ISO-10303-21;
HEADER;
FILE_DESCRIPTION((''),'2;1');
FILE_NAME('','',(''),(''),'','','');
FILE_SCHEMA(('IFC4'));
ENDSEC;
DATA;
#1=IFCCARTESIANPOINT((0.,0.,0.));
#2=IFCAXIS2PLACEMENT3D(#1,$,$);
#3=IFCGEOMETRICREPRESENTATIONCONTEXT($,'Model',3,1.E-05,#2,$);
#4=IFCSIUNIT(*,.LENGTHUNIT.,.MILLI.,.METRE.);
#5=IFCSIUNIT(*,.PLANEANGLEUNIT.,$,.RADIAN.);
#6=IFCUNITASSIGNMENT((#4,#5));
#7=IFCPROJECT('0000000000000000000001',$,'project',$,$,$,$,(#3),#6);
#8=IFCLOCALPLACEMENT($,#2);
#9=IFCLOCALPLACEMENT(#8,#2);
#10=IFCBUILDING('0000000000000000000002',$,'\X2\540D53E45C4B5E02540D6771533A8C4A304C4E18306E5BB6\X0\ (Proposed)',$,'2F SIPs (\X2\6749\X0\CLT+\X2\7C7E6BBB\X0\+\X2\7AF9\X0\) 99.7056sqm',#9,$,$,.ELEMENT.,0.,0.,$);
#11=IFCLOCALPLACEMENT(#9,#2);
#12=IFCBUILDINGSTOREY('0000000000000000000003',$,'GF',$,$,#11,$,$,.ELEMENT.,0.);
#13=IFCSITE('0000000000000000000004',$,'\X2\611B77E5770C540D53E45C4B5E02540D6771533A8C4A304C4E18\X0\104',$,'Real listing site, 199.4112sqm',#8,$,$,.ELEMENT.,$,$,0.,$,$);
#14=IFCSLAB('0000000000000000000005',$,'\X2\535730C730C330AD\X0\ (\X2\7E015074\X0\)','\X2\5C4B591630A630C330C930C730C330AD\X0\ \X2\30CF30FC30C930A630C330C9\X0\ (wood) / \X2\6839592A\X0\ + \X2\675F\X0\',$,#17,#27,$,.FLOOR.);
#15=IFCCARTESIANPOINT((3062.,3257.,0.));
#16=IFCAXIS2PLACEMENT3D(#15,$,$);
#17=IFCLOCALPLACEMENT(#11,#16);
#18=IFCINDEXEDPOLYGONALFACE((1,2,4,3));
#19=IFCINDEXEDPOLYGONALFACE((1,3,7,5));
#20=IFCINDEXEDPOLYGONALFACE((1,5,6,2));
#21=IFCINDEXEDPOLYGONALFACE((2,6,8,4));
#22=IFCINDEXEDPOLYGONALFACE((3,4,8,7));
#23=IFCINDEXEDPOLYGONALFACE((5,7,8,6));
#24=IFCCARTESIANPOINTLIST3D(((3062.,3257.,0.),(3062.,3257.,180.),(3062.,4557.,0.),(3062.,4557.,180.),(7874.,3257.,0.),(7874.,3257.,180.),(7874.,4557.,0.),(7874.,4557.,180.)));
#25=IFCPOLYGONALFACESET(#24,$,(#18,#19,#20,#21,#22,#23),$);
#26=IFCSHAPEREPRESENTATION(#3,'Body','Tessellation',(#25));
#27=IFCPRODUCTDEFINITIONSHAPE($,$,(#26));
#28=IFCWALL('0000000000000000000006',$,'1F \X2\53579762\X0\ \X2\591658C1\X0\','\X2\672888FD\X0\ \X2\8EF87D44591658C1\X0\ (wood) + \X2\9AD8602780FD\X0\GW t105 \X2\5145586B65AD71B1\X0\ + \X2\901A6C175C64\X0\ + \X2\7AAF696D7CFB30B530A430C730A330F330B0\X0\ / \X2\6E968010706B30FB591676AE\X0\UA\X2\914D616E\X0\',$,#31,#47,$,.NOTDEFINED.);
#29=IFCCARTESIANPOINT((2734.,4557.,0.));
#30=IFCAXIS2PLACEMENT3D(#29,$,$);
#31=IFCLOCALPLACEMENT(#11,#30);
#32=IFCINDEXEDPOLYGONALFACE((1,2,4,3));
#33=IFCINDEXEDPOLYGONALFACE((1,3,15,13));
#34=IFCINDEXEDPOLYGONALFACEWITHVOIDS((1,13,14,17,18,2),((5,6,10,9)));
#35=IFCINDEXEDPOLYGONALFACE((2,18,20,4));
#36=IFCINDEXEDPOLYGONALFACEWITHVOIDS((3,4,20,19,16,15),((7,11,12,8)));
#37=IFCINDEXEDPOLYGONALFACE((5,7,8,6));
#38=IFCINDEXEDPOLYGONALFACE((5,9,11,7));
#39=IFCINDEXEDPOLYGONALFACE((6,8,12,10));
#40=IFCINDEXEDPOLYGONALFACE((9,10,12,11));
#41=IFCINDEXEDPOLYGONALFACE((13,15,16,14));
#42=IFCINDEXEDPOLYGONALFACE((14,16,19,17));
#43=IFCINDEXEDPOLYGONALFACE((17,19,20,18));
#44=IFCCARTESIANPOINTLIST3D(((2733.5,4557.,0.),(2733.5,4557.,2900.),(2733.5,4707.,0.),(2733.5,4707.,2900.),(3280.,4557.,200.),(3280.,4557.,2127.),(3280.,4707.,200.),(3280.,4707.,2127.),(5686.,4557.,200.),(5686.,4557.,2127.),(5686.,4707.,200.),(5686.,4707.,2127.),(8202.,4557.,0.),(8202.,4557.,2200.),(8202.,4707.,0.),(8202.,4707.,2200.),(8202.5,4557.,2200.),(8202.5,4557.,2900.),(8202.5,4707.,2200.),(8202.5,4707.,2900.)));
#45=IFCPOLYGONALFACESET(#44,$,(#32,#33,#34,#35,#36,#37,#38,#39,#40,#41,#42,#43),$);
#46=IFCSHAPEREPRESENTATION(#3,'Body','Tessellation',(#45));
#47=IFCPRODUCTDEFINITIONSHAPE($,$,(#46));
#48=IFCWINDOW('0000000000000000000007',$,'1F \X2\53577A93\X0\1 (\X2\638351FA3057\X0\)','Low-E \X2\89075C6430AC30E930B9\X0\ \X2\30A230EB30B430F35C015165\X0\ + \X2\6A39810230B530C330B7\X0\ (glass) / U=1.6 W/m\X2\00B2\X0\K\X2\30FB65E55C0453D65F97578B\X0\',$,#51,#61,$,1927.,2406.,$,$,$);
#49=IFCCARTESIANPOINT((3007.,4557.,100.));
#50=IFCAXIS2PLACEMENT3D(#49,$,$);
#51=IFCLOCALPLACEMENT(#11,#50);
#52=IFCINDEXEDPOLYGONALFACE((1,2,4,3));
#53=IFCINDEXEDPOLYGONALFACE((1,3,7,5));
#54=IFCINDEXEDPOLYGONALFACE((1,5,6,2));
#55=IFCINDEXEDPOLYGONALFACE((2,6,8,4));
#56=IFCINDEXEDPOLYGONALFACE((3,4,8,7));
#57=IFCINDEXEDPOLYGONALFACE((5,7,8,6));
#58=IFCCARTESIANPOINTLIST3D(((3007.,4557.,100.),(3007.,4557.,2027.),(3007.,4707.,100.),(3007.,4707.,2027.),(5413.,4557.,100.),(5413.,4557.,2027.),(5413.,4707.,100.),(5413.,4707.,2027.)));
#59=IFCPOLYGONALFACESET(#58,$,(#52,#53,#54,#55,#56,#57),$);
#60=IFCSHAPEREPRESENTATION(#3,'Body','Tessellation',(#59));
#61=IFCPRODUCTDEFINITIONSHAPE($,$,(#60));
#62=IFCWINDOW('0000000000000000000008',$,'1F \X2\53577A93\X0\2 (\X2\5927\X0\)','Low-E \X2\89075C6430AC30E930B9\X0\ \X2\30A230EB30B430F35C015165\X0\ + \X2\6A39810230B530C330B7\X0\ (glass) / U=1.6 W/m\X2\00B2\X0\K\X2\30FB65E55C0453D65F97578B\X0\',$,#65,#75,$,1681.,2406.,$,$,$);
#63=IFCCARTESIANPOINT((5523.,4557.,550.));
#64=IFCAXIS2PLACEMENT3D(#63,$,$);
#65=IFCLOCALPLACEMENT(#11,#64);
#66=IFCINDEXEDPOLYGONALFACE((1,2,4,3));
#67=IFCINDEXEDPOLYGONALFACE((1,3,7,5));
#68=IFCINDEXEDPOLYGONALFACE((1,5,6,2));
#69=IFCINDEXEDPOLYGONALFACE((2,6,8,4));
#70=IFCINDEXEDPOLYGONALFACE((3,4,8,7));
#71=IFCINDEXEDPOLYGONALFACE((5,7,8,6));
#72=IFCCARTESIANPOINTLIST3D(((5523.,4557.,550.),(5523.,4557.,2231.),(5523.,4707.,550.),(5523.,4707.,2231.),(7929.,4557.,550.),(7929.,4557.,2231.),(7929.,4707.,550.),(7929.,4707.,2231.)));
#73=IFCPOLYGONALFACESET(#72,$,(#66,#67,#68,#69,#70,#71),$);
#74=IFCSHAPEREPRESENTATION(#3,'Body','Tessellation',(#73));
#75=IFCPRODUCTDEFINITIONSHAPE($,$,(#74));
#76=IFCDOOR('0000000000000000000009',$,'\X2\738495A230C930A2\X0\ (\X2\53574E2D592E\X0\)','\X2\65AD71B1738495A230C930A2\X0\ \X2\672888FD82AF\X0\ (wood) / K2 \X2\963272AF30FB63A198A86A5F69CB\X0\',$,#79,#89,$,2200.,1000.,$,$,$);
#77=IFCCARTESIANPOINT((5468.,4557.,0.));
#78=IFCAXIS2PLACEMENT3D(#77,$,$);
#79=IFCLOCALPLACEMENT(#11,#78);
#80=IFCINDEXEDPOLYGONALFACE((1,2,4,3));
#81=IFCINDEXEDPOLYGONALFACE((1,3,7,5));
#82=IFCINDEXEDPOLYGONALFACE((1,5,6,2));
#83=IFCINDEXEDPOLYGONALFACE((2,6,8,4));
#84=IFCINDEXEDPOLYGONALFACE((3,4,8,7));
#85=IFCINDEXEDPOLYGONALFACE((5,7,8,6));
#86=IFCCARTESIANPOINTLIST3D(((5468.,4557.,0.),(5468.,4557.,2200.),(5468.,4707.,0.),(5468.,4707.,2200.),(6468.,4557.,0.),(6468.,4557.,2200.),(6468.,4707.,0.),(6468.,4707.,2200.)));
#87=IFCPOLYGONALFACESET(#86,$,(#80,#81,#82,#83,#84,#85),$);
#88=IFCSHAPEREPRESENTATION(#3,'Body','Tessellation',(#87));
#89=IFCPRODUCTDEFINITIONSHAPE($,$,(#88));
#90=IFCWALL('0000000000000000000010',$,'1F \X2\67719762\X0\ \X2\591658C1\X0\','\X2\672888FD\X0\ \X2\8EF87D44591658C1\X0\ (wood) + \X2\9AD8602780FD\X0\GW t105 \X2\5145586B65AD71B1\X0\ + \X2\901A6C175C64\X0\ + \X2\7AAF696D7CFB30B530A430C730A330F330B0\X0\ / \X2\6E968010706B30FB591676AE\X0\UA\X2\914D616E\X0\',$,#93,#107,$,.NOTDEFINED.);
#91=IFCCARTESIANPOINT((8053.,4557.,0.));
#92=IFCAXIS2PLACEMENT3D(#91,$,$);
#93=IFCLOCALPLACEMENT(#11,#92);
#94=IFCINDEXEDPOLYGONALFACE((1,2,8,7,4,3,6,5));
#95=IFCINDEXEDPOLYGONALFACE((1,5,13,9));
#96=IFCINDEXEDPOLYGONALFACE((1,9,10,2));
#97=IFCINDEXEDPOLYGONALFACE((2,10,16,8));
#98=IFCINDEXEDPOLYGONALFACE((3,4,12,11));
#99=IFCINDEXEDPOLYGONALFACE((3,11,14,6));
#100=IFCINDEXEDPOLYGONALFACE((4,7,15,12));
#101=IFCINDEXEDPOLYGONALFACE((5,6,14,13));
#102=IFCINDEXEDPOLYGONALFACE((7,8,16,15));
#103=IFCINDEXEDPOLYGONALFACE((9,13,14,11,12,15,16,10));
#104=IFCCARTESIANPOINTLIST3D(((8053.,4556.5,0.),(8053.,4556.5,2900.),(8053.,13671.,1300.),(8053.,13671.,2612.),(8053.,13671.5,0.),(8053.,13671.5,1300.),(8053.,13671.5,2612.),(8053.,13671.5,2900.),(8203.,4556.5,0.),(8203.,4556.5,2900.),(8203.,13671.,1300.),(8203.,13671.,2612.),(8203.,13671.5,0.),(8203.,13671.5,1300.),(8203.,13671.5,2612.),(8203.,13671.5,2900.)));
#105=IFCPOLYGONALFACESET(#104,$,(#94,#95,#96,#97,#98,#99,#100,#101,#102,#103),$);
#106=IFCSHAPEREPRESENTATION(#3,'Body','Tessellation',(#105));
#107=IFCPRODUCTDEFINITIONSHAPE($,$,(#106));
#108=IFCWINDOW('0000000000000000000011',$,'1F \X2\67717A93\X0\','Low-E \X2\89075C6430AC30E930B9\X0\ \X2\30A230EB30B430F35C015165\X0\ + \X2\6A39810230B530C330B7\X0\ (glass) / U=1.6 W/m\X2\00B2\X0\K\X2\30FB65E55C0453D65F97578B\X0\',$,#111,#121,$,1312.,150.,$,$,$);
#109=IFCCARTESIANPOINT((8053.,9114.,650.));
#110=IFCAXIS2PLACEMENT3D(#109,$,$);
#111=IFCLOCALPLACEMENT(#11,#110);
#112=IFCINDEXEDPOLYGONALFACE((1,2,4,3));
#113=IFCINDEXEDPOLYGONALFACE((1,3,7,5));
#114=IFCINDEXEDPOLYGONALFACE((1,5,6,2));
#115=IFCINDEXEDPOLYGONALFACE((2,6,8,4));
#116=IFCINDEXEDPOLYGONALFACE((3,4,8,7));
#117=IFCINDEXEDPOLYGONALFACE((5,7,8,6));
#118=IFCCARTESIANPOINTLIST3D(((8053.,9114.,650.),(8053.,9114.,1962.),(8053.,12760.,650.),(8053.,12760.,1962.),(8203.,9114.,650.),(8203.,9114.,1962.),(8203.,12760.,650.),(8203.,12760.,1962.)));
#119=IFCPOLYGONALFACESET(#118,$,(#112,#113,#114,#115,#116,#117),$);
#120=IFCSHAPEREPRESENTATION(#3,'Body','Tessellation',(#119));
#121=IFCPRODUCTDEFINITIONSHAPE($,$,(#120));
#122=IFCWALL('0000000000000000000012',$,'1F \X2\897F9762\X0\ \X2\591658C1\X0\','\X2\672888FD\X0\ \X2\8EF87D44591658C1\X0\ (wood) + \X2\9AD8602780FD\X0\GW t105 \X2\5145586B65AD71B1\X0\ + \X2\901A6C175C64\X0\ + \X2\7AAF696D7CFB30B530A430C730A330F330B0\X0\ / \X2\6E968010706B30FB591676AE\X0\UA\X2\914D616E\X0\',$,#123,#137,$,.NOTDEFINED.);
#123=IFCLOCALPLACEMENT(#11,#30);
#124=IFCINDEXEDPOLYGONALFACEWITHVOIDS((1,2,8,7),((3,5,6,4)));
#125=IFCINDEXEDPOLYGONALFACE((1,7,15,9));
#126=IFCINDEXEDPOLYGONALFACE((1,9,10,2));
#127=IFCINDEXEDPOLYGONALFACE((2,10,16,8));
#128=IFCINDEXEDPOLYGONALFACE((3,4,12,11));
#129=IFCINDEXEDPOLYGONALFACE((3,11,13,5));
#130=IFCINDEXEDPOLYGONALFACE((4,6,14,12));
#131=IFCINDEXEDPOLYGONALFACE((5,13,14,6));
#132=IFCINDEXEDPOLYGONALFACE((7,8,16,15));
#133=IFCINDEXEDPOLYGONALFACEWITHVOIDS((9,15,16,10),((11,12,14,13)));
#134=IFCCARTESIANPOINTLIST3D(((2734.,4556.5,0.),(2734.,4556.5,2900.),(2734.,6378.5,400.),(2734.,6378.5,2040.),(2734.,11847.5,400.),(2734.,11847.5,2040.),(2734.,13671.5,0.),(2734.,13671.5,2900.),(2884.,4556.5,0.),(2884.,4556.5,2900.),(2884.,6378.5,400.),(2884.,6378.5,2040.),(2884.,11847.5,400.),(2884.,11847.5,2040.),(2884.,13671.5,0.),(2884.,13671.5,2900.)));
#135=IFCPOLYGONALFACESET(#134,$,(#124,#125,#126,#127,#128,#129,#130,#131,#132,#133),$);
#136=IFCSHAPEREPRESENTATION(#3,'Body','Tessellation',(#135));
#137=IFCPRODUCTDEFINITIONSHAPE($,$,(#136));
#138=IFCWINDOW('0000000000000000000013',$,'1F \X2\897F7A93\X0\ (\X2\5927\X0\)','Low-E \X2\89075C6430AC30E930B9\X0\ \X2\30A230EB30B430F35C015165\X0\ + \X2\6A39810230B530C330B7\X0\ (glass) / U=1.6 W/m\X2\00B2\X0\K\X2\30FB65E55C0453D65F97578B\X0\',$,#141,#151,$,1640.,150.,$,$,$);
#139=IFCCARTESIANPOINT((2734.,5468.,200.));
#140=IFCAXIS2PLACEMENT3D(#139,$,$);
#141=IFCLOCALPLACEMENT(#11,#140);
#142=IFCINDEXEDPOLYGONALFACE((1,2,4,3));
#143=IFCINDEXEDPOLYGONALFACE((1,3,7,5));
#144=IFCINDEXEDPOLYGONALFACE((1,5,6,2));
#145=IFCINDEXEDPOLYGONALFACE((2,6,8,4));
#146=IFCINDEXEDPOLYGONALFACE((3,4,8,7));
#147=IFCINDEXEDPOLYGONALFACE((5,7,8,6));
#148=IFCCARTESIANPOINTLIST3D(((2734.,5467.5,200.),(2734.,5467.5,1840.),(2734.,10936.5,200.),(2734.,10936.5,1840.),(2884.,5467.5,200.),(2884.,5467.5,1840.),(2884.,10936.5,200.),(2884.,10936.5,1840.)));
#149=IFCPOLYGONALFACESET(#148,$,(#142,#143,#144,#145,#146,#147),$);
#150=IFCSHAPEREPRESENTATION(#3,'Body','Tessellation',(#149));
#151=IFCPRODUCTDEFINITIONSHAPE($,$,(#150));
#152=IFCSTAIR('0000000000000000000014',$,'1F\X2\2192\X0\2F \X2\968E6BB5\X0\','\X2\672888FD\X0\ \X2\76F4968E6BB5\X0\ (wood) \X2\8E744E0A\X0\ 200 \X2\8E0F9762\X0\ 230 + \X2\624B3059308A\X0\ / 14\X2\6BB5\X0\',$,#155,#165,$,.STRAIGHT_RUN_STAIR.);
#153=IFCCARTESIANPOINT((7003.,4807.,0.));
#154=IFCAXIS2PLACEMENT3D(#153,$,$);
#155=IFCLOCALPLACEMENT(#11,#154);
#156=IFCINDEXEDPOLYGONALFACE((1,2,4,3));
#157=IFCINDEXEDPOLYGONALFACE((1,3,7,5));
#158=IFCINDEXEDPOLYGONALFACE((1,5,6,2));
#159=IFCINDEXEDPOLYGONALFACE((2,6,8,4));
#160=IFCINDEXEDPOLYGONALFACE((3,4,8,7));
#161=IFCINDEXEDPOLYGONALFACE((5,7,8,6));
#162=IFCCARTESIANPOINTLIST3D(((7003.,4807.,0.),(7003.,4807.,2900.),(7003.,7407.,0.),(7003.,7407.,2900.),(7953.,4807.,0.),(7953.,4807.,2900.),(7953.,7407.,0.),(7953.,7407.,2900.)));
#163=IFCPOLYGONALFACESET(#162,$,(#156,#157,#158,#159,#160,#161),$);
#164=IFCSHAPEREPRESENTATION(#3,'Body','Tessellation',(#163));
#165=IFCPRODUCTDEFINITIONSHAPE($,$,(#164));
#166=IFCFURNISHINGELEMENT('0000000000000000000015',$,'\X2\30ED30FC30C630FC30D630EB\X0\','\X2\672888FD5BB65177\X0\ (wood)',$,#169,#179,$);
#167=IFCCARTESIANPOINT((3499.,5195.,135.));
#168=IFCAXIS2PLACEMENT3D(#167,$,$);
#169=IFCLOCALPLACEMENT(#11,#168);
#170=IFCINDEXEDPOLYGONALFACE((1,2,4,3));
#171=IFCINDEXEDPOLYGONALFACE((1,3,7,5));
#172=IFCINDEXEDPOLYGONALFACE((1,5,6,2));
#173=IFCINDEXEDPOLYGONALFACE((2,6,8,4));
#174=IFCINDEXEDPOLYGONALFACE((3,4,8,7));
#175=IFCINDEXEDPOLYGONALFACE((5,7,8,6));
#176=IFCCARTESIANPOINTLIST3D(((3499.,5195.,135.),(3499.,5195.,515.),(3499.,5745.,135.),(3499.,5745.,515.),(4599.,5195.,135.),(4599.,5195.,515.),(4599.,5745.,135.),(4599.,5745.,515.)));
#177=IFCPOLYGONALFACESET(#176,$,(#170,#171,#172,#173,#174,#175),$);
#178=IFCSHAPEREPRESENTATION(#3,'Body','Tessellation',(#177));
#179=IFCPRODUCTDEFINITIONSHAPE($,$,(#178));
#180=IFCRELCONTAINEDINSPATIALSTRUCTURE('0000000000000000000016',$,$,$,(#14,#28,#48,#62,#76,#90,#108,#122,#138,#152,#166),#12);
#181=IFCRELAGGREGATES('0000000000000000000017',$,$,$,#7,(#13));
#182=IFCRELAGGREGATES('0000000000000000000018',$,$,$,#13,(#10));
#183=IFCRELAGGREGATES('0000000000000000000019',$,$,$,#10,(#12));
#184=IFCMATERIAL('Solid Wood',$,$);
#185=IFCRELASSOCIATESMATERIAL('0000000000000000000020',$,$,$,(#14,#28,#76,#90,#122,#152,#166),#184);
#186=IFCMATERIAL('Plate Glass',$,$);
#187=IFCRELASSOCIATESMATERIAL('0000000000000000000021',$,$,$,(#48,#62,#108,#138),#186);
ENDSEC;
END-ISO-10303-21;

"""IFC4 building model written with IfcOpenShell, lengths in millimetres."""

from ifc_helpers import new_model, si_unit, frame, frame_2d, origin, place, context, project, spatial, rectangle, extrude, material, element, fill, save


model = new_model("IFC4")

# Units and contexts
model_context = context("Model", 3, precision=1e-05, world=origin())
ifc_project = project(units=[si_unit("LENGTHUNIT", "METRE", prefix="MILLI"), si_unit("PLANEANGLEUNIT", "RADIAN")], contexts=[model_context])

# Site, building, storey
site_placement = place(None, origin())
site = spatial("IfcSite", under=ifc_project, at=site_placement, Name="愛知県名古屋市名東区豊が丘104", ObjectType="Real listing site, 199.4112sqm", CompositionType="ELEMENT", RefElevation=0.0)
building_placement = place(site_placement, origin())
building = spatial("IfcBuilding", under=site, at=building_placement, Name="名古屋市名東区豊が丘の家 (Proposed)", ObjectType="2F SIPs (杉CLT+籾殻+竹) 99.7056sqm", CompositionType="ELEMENT", ElevationOfRefHeight=0.0, ElevationOfTerrain=0.0)
storey_placement = place(building_placement, origin())
storey = spatial("IfcBuildingStorey", under=building, at=storey_placement, Name="GF", CompositionType="ELEMENT", Elevation=0.0)

# Slab
ifc_material_1 = material(Name="Solid Wood")
slab_1_placement = place(storey_placement, frame((3062.0, 3257.0, 0.0)))
element("IfcSlab", 1, at=slab_1_placement, inside=storey, material=ifc_material_1, Name="南デッキ (縁側)", Description="屋外ウッドデッキ ハードウッド (wood) / 根太 + 束", PredefinedType="FLOOR", context=model_context, shape_type="SweptSolid", body=[
    extrude(rectangle(XDim=4812.0, YDim=1300.0, at=frame_2d((2406.0, 650.0))), frame((3062.0, 3257.0, 0.0)), (0.0, 0.0, 1.0), 180.0),
])

# Wall, openings, windows, door
wall_1_placement = place(storey_placement, frame((2734.0, 4557.0, 0.0)))
wall_1 = element("IfcWall", 2, at=wall_1_placement, inside=storey, material=ifc_material_1, Name="1F 南面 外壁", Description="木製 軸組外壁 (wood) + 高性能GW t105 充填断熱 + 通気層 + 窯業系サイディング / 準耐火・外皮UA配慮", PredefinedType="NOTDEFINED", context=model_context, shape_type="SweptSolid", body=[
    extrude(rectangle(XDim=5469.0, YDim=150.0, at=frame_2d((2734.0, 75.0))), frame((2734.0, 4557.0, 0.0)), (0.0, 0.0, 1.0), 2900.0),
])
opening_1_placement = place(storey_placement, frame((3007.0, 4557.0, 100.0)))
opening_1 = element("IfcOpeningElement", 3, at=opening_1_placement, cuts=wall_1, PredefinedType="NOTDEFINED", context=model_context, shape_type="SweptSolid", body=[
    extrude(rectangle(XDim=2406.0, YDim=150.0, at=frame_2d((1203.0, 75.0))), frame((3007.0, 4557.0, 100.0)), (0.0, 0.0, 1.0), 1927.0),
])
opening_2_placement = place(storey_placement, frame((5523.0, 4557.0, 550.0)))
opening_2 = element("IfcOpeningElement", 4, at=opening_2_placement, cuts=wall_1, PredefinedType="NOTDEFINED", context=model_context, shape_type="SweptSolid", body=[
    extrude(rectangle(XDim=2406.0, YDim=150.0, at=frame_2d((1203.0, 75.0))), frame((5523.0, 4557.0, 550.0)), (0.0, 0.0, 1.0), 1681.0),
])
opening_3_placement = place(storey_placement, frame((5468.0, 4557.0, 0.0)))
opening_3 = element("IfcOpeningElement", 5, at=opening_3_placement, cuts=wall_1, PredefinedType="NOTDEFINED", context=model_context, shape_type="SweptSolid", body=[
    extrude(rectangle(XDim=1000.0, YDim=150.0, at=frame_2d((500.0, 75.0))), frame((5468.0, 4557.0, 0.0)), (0.0, 0.0, 1.0), 2200.0),
])
ifc_material_2 = material(Name="Plate Glass")
window_1_placement = place(storey_placement, frame((3007.0, 4557.0, 100.0)))
window_1 = element("IfcWindow", 6, at=window_1_placement, inside=storey, material=ifc_material_2, Name="1F 南窓1 (掃出し)", Description="Low-E 複層ガラス アルゴン封入 + 樹脂サッシ (glass) / U=1.6 W/m²K・日射取得型", OverallHeight=1927.0, OverallWidth=2406.0, context=model_context, shape_type="SweptSolid", body=[
    extrude(rectangle(XDim=2406.0, YDim=150.0, at=frame_2d((1203.0, 75.0))), frame((3007.0, 4557.0, 100.0)), (0.0, 0.0, 1.0), 1927.0),
])
fill(opening_1, window_1)
window_2_placement = place(storey_placement, frame((5523.0, 4557.0, 550.0)))
window_2 = element("IfcWindow", 7, at=window_2_placement, inside=storey, material=ifc_material_2, Name="1F 南窓2 (大)", Description="Low-E 複層ガラス アルゴン封入 + 樹脂サッシ (glass) / U=1.6 W/m²K・日射取得型", OverallHeight=1681.0, OverallWidth=2406.0, context=model_context, shape_type="SweptSolid", body=[
    extrude(rectangle(XDim=2406.0, YDim=150.0, at=frame_2d((1203.0, 75.0))), frame((5523.0, 4557.0, 550.0)), (0.0, 0.0, 1.0), 1681.0),
])
fill(opening_2, window_2)
door_placement = place(storey_placement, frame((5468.0, 4557.0, 0.0)))
door = element("IfcDoor", 8, at=door_placement, inside=storey, material=ifc_material_1, Name="玄関ドア (南中央)", Description="断熱玄関ドア 木製芯 (wood) / K2 防犯・採風機構", OverallHeight=2200.0, OverallWidth=1000.0, context=model_context, shape_type="SweptSolid", body=[
    extrude(rectangle(XDim=1000.0, YDim=150.0, at=frame_2d((500.0, 75.0))), frame((5468.0, 4557.0, 0.0)), (0.0, 0.0, 1.0), 2200.0),
])
fill(opening_3, door)

# Walls, openings, windows
wall_2_placement = place(storey_placement, frame((8053.0, 4557.0, 0.0)))
wall_2 = element("IfcWall", 9, at=wall_2_placement, inside=storey, material=ifc_material_1, Name="1F 東面 外壁", Description="木製 軸組外壁 (wood) + 高性能GW t105 充填断熱 + 通気層 + 窯業系サイディング / 準耐火・外皮UA配慮", PredefinedType="NOTDEFINED", context=model_context, shape_type="SweptSolid", body=[
    extrude(rectangle(XDim=150.0, YDim=9115.0, at=frame_2d((75.0, 4557.0))), frame((8053.0, 4557.0, 0.0)), (0.0, 0.0, 1.0), 2900.0),
])
opening_4_placement = place(storey_placement, frame((8053.0, 9114.0, 650.0)))
opening_4 = element("IfcOpeningElement", 10, at=opening_4_placement, cuts=wall_2, PredefinedType="NOTDEFINED", context=model_context, shape_type="SweptSolid", body=[
    extrude(rectangle(XDim=150.0, YDim=3646.0, at=frame_2d((75.0, 1823.0))), frame((8053.0, 9114.0, 650.0)), (0.0, 0.0, 1.0), 1312.0),
])
window_3_placement = place(storey_placement, frame((8053.0, 9114.0, 650.0)))
window_3 = element("IfcWindow", 11, at=window_3_placement, inside=storey, material=ifc_material_2, Name="1F 東窓", Description="Low-E 複層ガラス アルゴン封入 + 樹脂サッシ (glass) / U=1.6 W/m²K・日射取得型", OverallHeight=1312.0, OverallWidth=150.0, context=model_context, shape_type="SweptSolid", body=[
    extrude(rectangle(XDim=150.0, YDim=3646.0, at=frame_2d((75.0, 1823.0))), frame((8053.0, 9114.0, 650.0)), (0.0, 0.0, 1.0), 1312.0),
])
fill(opening_4, window_3)
wall_3_placement = place(storey_placement, frame((2734.0, 4557.0, 0.0)))
wall_3 = element("IfcWall", 12, at=wall_3_placement, inside=storey, material=ifc_material_1, Name="1F 西面 外壁", Description="木製 軸組外壁 (wood) + 高性能GW t105 充填断熱 + 通気層 + 窯業系サイディング / 準耐火・外皮UA配慮", PredefinedType="NOTDEFINED", context=model_context, shape_type="SweptSolid", body=[
    extrude(rectangle(XDim=150.0, YDim=9115.0, at=frame_2d((75.0, 4557.0))), frame((2734.0, 4557.0, 0.0)), (0.0, 0.0, 1.0), 2900.0),
])
opening_5_placement = place(storey_placement, frame((2734.0, 5468.0, 200.0)))
opening_5 = element("IfcOpeningElement", 13, at=opening_5_placement, cuts=wall_3, PredefinedType="NOTDEFINED", context=model_context, shape_type="SweptSolid", body=[
    extrude(rectangle(XDim=150.0, YDim=5469.0, at=frame_2d((75.0, 2734.0))), frame((2734.0, 5468.0, 200.0)), (0.0, 0.0, 1.0), 1640.0),
])
window_4_placement = place(storey_placement, frame((2734.0, 5468.0, 200.0)))
window_4 = element("IfcWindow", 14, at=window_4_placement, inside=storey, material=ifc_material_2, Name="1F 西窓 (大)", Description="Low-E 複層ガラス アルゴン封入 + 樹脂サッシ (glass) / U=1.6 W/m²K・日射取得型", OverallHeight=1640.0, OverallWidth=150.0, context=model_context, shape_type="SweptSolid", body=[
    extrude(rectangle(XDim=150.0, YDim=5469.0, at=frame_2d((75.0, 2734.0))), frame((2734.0, 5468.0, 200.0)), (0.0, 0.0, 1.0), 1640.0),
])
fill(opening_5, window_4)

# Stair
stair_placement = place(storey_placement, frame((7003.0, 4807.0, 0.0)))
element("IfcStair", 15, at=stair_placement, inside=storey, material=ifc_material_1, Name="1F→2F 階段", Description="木製 直階段 (wood) 蹴上 200 踏面 230 + 手すり / 14段", PredefinedType="STRAIGHT_RUN_STAIR", context=model_context, shape_type="SweptSolid", body=[
    extrude(rectangle(XDim=950.0, YDim=2600.0, at=frame_2d((475.0, 1300.0))), frame((7003.0, 4807.0, 0.0)), (0.0, 0.0, 1.0), 2900.0),
])

# Furnishing element
furnishing_1_placement = place(storey_placement, frame((3499.0, 5195.0, 135.0)))
element("IfcFurnishingElement", 16, at=furnishing_1_placement, inside=storey, material=ifc_material_1, Name="ローテーブル", Description="木製家具 (wood)", context=model_context, shape_type="SweptSolid", body=[
    extrude(rectangle(XDim=1100.0, YDim=550.0, at=frame_2d((550.0, 275.0))), frame((3499.0, 5195.0, 135.0)), (0.0, 0.0, 1.0), 380.0),
])

save(model, "model.ifc")
